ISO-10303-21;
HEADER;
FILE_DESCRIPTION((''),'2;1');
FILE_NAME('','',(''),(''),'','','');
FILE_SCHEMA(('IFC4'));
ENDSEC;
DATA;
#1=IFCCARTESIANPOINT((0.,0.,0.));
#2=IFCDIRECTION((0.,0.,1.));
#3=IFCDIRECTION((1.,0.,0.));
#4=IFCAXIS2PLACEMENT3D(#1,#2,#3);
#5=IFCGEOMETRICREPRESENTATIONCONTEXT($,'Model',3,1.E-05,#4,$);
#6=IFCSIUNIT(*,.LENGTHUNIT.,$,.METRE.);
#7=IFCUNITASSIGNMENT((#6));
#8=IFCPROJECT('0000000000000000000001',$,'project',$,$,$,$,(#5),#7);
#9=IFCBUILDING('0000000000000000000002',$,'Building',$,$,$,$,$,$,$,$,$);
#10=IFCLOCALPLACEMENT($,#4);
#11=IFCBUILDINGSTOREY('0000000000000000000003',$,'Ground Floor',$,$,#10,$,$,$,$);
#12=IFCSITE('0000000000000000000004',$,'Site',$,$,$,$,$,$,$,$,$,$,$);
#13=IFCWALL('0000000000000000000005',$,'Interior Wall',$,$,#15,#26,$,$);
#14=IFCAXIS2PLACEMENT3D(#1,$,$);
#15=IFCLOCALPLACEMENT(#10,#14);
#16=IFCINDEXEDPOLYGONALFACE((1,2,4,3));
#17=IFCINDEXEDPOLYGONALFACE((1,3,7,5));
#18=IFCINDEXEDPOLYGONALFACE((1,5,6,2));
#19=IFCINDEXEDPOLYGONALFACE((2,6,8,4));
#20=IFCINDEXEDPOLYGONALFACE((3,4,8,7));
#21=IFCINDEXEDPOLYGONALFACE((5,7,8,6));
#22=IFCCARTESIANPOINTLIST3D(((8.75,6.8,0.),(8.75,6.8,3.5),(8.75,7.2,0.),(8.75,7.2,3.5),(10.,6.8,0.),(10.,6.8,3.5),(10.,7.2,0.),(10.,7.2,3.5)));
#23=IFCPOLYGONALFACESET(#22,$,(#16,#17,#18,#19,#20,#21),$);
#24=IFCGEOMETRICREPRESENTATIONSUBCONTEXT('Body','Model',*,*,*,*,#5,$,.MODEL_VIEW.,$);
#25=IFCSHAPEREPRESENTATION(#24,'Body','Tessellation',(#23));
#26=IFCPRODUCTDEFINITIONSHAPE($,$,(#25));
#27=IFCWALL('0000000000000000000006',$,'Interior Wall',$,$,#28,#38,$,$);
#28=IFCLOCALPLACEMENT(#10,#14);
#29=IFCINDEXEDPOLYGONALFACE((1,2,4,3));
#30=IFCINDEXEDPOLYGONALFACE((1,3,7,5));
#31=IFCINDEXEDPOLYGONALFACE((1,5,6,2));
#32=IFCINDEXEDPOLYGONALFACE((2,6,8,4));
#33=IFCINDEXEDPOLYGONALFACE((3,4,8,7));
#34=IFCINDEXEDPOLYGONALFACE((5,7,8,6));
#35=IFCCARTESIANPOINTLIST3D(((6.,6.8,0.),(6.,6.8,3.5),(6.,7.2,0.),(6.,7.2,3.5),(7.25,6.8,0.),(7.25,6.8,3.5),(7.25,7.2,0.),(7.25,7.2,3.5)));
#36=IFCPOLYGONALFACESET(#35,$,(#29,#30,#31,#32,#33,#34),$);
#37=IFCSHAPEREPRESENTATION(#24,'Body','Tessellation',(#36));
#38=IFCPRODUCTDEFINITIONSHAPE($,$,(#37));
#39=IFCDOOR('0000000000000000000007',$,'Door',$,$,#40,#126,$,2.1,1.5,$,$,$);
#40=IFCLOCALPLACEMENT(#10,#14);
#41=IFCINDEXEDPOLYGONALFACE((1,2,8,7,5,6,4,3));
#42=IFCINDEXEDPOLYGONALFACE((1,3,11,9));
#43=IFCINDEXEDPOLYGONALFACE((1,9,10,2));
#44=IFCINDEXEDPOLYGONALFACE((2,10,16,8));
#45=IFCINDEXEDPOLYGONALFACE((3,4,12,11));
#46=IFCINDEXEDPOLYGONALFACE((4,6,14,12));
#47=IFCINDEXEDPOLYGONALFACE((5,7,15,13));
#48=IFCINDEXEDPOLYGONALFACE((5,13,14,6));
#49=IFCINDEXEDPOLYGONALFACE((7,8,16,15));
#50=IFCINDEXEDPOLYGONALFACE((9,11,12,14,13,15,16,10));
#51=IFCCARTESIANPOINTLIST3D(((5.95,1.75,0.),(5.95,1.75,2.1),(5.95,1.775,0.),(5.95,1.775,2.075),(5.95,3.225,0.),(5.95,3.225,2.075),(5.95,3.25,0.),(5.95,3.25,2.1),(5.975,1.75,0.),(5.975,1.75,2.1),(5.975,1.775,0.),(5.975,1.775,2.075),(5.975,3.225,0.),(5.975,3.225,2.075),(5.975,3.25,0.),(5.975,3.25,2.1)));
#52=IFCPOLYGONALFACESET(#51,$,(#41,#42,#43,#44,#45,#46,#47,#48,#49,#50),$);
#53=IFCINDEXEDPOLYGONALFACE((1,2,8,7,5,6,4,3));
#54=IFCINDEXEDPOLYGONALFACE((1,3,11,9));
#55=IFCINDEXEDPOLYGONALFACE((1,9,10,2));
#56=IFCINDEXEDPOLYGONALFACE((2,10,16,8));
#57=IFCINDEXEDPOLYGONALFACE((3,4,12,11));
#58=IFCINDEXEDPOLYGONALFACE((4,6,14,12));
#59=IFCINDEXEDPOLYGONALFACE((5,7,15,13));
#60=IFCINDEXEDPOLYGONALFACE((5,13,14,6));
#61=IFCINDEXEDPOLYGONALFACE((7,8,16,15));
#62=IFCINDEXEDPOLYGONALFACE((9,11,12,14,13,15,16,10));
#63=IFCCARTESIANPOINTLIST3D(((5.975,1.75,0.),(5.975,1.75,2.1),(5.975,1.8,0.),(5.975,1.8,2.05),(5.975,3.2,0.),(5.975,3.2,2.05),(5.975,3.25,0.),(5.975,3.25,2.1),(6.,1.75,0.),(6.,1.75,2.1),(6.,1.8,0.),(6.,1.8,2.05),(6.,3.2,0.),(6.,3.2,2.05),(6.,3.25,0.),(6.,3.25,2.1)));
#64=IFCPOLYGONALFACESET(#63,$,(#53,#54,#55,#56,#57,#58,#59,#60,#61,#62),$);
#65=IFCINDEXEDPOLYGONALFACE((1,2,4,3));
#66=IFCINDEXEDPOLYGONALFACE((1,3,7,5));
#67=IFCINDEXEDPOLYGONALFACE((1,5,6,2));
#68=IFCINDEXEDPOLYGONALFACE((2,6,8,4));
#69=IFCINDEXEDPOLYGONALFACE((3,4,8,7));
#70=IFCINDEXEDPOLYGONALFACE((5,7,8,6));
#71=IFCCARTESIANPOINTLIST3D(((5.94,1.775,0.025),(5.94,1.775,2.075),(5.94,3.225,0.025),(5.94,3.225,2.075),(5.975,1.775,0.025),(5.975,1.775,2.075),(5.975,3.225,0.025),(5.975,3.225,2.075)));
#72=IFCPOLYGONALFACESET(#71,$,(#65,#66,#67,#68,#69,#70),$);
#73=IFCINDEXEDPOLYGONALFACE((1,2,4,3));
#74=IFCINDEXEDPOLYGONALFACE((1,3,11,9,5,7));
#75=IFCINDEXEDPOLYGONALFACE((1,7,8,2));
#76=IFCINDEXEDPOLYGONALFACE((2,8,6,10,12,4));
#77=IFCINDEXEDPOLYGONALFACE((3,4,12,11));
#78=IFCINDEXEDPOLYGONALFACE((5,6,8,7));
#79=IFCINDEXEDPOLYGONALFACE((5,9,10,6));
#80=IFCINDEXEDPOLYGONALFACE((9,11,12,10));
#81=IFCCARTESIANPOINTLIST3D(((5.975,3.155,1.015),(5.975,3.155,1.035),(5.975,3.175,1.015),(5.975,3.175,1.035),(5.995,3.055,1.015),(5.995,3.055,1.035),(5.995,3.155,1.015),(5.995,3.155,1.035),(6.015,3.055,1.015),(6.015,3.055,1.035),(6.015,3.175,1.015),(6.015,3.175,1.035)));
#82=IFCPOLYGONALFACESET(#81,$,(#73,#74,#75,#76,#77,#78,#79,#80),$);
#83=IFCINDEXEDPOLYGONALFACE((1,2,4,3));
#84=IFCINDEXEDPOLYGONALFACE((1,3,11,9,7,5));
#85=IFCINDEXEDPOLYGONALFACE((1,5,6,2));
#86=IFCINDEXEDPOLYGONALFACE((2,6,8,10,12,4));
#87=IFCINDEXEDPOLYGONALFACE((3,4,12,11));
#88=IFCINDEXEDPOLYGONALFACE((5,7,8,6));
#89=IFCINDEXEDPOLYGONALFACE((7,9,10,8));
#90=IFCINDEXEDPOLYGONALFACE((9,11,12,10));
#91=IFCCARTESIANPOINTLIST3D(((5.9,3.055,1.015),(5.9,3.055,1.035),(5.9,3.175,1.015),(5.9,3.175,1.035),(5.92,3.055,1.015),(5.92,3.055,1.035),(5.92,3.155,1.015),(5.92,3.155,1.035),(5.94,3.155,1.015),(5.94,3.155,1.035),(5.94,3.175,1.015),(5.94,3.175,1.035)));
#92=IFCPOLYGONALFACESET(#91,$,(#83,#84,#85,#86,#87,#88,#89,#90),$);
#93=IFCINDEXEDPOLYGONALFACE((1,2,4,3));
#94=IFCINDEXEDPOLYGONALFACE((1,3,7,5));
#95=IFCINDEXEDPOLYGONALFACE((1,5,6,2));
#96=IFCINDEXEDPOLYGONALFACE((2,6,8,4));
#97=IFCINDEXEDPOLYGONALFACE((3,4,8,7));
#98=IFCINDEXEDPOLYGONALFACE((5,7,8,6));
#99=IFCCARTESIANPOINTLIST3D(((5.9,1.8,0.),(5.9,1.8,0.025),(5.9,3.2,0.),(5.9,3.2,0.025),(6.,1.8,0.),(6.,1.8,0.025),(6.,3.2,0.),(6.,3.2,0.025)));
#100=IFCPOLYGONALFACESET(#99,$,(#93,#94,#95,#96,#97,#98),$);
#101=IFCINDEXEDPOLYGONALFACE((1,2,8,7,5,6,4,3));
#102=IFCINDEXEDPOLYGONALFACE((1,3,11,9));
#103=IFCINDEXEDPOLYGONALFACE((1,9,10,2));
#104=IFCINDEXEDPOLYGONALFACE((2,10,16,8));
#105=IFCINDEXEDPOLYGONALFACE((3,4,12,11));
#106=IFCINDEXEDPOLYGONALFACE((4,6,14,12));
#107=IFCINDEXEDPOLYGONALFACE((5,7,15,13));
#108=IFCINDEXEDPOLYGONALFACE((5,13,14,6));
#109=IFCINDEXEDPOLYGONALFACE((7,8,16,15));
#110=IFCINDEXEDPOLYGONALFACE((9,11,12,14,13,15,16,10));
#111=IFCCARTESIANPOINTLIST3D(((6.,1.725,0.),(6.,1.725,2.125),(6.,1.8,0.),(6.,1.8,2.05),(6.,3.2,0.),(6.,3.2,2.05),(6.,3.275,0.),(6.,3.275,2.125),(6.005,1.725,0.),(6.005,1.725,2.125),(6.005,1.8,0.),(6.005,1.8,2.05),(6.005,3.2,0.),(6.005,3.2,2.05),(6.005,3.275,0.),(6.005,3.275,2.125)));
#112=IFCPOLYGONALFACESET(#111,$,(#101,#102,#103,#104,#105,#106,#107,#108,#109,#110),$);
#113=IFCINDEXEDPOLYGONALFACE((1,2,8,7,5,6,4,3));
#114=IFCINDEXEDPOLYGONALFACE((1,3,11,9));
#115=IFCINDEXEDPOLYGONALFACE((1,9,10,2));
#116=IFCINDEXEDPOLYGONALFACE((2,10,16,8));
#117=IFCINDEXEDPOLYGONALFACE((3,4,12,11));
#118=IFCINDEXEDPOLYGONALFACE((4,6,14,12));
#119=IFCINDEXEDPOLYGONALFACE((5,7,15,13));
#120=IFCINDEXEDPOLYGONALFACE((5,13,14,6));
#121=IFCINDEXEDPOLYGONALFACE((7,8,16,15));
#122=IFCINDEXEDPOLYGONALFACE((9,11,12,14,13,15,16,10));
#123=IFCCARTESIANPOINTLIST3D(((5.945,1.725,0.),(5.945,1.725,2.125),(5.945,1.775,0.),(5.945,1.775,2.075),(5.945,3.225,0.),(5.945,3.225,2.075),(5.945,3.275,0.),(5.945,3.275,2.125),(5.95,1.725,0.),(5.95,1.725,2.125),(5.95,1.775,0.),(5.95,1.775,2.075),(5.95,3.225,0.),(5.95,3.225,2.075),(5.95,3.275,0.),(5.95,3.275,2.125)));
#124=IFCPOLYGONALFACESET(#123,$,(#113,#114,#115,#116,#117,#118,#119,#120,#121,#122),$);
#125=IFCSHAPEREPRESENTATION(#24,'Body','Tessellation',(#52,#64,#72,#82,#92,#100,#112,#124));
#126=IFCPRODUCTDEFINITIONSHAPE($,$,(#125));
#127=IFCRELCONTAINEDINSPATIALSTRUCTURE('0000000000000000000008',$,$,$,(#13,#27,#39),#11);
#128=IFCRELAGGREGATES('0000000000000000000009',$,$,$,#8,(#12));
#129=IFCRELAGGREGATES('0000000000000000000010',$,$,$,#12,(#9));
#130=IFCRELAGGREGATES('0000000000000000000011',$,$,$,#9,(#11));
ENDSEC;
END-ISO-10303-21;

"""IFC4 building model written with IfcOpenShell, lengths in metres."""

from ifc_helpers import new_model, si_unit, frame, origin_with_axes, place, context, subcontext, project, spatial, line, indexed_curve, outline, extrude, element, save


model = new_model("IFC4")

# Units and contexts
model_context = context("Model", 3, precision=1e-05, world=origin_with_axes())
body_context = subcontext(model_context, "Body", "Model", "MODEL_VIEW")
ifc_project = project(units=[si_unit("LENGTHUNIT", "METRE")], contexts=[model_context])

# Site, building, storey
site = spatial("IfcSite", under=ifc_project, Name="Site")
building = spatial("IfcBuilding", under=site, Name="Building")
storey_placement = place(None, origin_with_axes())
storey = spatial("IfcBuildingStorey", under=building, at=storey_placement, Name="Ground Floor")

# Walls
for number, where, z_axis, x_axis, name in (
    (1, (10.0, 7.0, 0.0), (0.0, 0.0, 1.0), (-1.0, 0.0, 0.0), "Interior Wall"),
    (2, (7.25, 7.0, 0.0), (0.0, 0.0, 1.0), (-1.0, 0.0, 0.0), "Interior Wall"),
):
    element("IfcWall", number, at=place(storey_placement, frame(where, z_axis=z_axis, x_axis=x_axis)), inside=storey, Name=name, context=body_context, shape_type="SweptSolid", body=[
        extrude(outline(indexed_curve([(0.0, 0.0), (0.0, 0.4), (1.25, 0.4), (1.25, 0.0), (0.0, 0.0)], self_intersect=False)), frame((0.0, -0.2, 0.0), z_axis=(0.0, 0.0, 1.0), x_axis=(1.0, 0.0, 0.0)), (0.0, 0.0, 1.0), 3.5),
    ])

# Door
door_1_placement = place(storey_placement, frame((6.0, 1.75, 0.0), z_axis=(0.0, 0.0, 1.0), x_axis=(0.0, 1.0, 0.0)))
element("IfcDoor", 3, at=door_1_placement, inside=storey, Name="Door", OverallHeight=2.1, OverallWidth=1.5, context=body_context, shape_type="SweptSolid", body=[
    extrude(outline(indexed_curve([(0.0, 0.0), (0.0, 2.1), (1.5, 2.1), (1.5, 0.0), (1.475, 0.0), (1.475, 2.075), (0.025, 2.075), (0.025, 0.0)], segments=[line(1, 2, 3, 4, 5, 6, 7, 8, 1)])), frame((0.0, 0.025, 0.0), z_axis=(0.0, -1.0, 0.0), x_axis=(1.0, 0.0, 0.0)), (0.0, 0.0, -1.0), 0.025),
    extrude(outline(indexed_curve([(0.0, 0.0), (0.0, 2.1), (1.5, 2.1), (1.5, 0.0), (1.45, 0.0), (1.45, 2.05), (0.05, 2.05), (0.05, 0.0)], segments=[line(1, 2, 3, 4, 5, 6, 7, 8, 1)])), frame((0.0, 0.0, 0.0), z_axis=(0.0, -1.0, 0.0), x_axis=(1.0, 0.0, 0.0)), (0.0, 0.0, -1.0), 0.025),
    extrude(outline(indexed_curve([(0.0, 0.0), (1.45, 0.0), (1.45, 0.035), (0.0, 0.035)], segments=[line(1, 2, 3, 4, 1)])), frame((0.025, 0.025, 0.025), z_axis=(0.0, 0.0, 1.0), x_axis=(1.0, 0.0, 0.0)), (0.0, 0.0, 1.0), 2.05),
    extrude(outline(indexed_curve([(0.0, 0.0), (0.0, -0.04), (-0.12, -0.04), (-0.12, -0.02), (-0.02, -0.02), (-0.02, 0.0)], segments=[line(1, 2, 3, 4, 5, 6, 1)])), frame((1.425, 0.025, 1.015), z_axis=(0.0, 0.0, 1.0), x_axis=(1.0, 0.0, 0.0)), (0.0, 0.0, 1.0), 0.02),
    extrude(outline(indexed_curve([(0.0, 0.0), (0.0, 0.04), (-0.12, 0.04), (-0.12, 0.02), (-0.02, 0.02), (-0.02, 0.0)], segments=[line(1, 2, 3, 4, 5, 6, 1)])), frame((1.425, 0.06, 1.015), z_axis=(0.0, 0.0, 1.0), x_axis=(1.0, 0.0, 0.0)), (0.0, 0.0, 1.0), 0.02),
    extrude(outline(indexed_curve([(0.0, 0.0), (1.4, 0.0), (1.4, 0.1), (0.0, 0.1)], segments=[line(1, 2, 3, 4, 1)])), frame((0.05, 0.0, 0.0), z_axis=(0.0, 0.0, 1.0), x_axis=(1.0, 0.0, 0.0)), (0.0, 0.0, 1.0), 0.025),
    extrude(outline(indexed_curve([(0.0, 0.0), (0.0, 2.125), (1.55, 2.125), (1.55, 0.0), (1.475, 0.0), (1.475, 2.05), (0.075, 2.05), (0.075, 0.0)], segments=[line(1, 2, 3, 4, 5, 6, 7, 8, 1)])), frame((-0.025, -0.005, 0.0), z_axis=(0.0, -1.0, 0.0), x_axis=(1.0, 0.0, 0.0)), (0.0, 0.0, -1.0), 0.005),
    extrude(outline(indexed_curve([(0.0, 0.0), (0.0, 2.125), (1.55, 2.125), (1.55, 0.0), (1.5, 0.0), (1.5, 2.075), (0.05, 2.075), (0.05, 0.0)], segments=[line(1, 2, 3, 4, 5, 6, 7, 8, 1)])), frame((-0.025, 0.05, 0.0), z_axis=(0.0, -1.0, 0.0), x_axis=(1.0, 0.0, 0.0)), (0.0, 0.0, -1.0), 0.005),
])

save(model, "model.ifc")
